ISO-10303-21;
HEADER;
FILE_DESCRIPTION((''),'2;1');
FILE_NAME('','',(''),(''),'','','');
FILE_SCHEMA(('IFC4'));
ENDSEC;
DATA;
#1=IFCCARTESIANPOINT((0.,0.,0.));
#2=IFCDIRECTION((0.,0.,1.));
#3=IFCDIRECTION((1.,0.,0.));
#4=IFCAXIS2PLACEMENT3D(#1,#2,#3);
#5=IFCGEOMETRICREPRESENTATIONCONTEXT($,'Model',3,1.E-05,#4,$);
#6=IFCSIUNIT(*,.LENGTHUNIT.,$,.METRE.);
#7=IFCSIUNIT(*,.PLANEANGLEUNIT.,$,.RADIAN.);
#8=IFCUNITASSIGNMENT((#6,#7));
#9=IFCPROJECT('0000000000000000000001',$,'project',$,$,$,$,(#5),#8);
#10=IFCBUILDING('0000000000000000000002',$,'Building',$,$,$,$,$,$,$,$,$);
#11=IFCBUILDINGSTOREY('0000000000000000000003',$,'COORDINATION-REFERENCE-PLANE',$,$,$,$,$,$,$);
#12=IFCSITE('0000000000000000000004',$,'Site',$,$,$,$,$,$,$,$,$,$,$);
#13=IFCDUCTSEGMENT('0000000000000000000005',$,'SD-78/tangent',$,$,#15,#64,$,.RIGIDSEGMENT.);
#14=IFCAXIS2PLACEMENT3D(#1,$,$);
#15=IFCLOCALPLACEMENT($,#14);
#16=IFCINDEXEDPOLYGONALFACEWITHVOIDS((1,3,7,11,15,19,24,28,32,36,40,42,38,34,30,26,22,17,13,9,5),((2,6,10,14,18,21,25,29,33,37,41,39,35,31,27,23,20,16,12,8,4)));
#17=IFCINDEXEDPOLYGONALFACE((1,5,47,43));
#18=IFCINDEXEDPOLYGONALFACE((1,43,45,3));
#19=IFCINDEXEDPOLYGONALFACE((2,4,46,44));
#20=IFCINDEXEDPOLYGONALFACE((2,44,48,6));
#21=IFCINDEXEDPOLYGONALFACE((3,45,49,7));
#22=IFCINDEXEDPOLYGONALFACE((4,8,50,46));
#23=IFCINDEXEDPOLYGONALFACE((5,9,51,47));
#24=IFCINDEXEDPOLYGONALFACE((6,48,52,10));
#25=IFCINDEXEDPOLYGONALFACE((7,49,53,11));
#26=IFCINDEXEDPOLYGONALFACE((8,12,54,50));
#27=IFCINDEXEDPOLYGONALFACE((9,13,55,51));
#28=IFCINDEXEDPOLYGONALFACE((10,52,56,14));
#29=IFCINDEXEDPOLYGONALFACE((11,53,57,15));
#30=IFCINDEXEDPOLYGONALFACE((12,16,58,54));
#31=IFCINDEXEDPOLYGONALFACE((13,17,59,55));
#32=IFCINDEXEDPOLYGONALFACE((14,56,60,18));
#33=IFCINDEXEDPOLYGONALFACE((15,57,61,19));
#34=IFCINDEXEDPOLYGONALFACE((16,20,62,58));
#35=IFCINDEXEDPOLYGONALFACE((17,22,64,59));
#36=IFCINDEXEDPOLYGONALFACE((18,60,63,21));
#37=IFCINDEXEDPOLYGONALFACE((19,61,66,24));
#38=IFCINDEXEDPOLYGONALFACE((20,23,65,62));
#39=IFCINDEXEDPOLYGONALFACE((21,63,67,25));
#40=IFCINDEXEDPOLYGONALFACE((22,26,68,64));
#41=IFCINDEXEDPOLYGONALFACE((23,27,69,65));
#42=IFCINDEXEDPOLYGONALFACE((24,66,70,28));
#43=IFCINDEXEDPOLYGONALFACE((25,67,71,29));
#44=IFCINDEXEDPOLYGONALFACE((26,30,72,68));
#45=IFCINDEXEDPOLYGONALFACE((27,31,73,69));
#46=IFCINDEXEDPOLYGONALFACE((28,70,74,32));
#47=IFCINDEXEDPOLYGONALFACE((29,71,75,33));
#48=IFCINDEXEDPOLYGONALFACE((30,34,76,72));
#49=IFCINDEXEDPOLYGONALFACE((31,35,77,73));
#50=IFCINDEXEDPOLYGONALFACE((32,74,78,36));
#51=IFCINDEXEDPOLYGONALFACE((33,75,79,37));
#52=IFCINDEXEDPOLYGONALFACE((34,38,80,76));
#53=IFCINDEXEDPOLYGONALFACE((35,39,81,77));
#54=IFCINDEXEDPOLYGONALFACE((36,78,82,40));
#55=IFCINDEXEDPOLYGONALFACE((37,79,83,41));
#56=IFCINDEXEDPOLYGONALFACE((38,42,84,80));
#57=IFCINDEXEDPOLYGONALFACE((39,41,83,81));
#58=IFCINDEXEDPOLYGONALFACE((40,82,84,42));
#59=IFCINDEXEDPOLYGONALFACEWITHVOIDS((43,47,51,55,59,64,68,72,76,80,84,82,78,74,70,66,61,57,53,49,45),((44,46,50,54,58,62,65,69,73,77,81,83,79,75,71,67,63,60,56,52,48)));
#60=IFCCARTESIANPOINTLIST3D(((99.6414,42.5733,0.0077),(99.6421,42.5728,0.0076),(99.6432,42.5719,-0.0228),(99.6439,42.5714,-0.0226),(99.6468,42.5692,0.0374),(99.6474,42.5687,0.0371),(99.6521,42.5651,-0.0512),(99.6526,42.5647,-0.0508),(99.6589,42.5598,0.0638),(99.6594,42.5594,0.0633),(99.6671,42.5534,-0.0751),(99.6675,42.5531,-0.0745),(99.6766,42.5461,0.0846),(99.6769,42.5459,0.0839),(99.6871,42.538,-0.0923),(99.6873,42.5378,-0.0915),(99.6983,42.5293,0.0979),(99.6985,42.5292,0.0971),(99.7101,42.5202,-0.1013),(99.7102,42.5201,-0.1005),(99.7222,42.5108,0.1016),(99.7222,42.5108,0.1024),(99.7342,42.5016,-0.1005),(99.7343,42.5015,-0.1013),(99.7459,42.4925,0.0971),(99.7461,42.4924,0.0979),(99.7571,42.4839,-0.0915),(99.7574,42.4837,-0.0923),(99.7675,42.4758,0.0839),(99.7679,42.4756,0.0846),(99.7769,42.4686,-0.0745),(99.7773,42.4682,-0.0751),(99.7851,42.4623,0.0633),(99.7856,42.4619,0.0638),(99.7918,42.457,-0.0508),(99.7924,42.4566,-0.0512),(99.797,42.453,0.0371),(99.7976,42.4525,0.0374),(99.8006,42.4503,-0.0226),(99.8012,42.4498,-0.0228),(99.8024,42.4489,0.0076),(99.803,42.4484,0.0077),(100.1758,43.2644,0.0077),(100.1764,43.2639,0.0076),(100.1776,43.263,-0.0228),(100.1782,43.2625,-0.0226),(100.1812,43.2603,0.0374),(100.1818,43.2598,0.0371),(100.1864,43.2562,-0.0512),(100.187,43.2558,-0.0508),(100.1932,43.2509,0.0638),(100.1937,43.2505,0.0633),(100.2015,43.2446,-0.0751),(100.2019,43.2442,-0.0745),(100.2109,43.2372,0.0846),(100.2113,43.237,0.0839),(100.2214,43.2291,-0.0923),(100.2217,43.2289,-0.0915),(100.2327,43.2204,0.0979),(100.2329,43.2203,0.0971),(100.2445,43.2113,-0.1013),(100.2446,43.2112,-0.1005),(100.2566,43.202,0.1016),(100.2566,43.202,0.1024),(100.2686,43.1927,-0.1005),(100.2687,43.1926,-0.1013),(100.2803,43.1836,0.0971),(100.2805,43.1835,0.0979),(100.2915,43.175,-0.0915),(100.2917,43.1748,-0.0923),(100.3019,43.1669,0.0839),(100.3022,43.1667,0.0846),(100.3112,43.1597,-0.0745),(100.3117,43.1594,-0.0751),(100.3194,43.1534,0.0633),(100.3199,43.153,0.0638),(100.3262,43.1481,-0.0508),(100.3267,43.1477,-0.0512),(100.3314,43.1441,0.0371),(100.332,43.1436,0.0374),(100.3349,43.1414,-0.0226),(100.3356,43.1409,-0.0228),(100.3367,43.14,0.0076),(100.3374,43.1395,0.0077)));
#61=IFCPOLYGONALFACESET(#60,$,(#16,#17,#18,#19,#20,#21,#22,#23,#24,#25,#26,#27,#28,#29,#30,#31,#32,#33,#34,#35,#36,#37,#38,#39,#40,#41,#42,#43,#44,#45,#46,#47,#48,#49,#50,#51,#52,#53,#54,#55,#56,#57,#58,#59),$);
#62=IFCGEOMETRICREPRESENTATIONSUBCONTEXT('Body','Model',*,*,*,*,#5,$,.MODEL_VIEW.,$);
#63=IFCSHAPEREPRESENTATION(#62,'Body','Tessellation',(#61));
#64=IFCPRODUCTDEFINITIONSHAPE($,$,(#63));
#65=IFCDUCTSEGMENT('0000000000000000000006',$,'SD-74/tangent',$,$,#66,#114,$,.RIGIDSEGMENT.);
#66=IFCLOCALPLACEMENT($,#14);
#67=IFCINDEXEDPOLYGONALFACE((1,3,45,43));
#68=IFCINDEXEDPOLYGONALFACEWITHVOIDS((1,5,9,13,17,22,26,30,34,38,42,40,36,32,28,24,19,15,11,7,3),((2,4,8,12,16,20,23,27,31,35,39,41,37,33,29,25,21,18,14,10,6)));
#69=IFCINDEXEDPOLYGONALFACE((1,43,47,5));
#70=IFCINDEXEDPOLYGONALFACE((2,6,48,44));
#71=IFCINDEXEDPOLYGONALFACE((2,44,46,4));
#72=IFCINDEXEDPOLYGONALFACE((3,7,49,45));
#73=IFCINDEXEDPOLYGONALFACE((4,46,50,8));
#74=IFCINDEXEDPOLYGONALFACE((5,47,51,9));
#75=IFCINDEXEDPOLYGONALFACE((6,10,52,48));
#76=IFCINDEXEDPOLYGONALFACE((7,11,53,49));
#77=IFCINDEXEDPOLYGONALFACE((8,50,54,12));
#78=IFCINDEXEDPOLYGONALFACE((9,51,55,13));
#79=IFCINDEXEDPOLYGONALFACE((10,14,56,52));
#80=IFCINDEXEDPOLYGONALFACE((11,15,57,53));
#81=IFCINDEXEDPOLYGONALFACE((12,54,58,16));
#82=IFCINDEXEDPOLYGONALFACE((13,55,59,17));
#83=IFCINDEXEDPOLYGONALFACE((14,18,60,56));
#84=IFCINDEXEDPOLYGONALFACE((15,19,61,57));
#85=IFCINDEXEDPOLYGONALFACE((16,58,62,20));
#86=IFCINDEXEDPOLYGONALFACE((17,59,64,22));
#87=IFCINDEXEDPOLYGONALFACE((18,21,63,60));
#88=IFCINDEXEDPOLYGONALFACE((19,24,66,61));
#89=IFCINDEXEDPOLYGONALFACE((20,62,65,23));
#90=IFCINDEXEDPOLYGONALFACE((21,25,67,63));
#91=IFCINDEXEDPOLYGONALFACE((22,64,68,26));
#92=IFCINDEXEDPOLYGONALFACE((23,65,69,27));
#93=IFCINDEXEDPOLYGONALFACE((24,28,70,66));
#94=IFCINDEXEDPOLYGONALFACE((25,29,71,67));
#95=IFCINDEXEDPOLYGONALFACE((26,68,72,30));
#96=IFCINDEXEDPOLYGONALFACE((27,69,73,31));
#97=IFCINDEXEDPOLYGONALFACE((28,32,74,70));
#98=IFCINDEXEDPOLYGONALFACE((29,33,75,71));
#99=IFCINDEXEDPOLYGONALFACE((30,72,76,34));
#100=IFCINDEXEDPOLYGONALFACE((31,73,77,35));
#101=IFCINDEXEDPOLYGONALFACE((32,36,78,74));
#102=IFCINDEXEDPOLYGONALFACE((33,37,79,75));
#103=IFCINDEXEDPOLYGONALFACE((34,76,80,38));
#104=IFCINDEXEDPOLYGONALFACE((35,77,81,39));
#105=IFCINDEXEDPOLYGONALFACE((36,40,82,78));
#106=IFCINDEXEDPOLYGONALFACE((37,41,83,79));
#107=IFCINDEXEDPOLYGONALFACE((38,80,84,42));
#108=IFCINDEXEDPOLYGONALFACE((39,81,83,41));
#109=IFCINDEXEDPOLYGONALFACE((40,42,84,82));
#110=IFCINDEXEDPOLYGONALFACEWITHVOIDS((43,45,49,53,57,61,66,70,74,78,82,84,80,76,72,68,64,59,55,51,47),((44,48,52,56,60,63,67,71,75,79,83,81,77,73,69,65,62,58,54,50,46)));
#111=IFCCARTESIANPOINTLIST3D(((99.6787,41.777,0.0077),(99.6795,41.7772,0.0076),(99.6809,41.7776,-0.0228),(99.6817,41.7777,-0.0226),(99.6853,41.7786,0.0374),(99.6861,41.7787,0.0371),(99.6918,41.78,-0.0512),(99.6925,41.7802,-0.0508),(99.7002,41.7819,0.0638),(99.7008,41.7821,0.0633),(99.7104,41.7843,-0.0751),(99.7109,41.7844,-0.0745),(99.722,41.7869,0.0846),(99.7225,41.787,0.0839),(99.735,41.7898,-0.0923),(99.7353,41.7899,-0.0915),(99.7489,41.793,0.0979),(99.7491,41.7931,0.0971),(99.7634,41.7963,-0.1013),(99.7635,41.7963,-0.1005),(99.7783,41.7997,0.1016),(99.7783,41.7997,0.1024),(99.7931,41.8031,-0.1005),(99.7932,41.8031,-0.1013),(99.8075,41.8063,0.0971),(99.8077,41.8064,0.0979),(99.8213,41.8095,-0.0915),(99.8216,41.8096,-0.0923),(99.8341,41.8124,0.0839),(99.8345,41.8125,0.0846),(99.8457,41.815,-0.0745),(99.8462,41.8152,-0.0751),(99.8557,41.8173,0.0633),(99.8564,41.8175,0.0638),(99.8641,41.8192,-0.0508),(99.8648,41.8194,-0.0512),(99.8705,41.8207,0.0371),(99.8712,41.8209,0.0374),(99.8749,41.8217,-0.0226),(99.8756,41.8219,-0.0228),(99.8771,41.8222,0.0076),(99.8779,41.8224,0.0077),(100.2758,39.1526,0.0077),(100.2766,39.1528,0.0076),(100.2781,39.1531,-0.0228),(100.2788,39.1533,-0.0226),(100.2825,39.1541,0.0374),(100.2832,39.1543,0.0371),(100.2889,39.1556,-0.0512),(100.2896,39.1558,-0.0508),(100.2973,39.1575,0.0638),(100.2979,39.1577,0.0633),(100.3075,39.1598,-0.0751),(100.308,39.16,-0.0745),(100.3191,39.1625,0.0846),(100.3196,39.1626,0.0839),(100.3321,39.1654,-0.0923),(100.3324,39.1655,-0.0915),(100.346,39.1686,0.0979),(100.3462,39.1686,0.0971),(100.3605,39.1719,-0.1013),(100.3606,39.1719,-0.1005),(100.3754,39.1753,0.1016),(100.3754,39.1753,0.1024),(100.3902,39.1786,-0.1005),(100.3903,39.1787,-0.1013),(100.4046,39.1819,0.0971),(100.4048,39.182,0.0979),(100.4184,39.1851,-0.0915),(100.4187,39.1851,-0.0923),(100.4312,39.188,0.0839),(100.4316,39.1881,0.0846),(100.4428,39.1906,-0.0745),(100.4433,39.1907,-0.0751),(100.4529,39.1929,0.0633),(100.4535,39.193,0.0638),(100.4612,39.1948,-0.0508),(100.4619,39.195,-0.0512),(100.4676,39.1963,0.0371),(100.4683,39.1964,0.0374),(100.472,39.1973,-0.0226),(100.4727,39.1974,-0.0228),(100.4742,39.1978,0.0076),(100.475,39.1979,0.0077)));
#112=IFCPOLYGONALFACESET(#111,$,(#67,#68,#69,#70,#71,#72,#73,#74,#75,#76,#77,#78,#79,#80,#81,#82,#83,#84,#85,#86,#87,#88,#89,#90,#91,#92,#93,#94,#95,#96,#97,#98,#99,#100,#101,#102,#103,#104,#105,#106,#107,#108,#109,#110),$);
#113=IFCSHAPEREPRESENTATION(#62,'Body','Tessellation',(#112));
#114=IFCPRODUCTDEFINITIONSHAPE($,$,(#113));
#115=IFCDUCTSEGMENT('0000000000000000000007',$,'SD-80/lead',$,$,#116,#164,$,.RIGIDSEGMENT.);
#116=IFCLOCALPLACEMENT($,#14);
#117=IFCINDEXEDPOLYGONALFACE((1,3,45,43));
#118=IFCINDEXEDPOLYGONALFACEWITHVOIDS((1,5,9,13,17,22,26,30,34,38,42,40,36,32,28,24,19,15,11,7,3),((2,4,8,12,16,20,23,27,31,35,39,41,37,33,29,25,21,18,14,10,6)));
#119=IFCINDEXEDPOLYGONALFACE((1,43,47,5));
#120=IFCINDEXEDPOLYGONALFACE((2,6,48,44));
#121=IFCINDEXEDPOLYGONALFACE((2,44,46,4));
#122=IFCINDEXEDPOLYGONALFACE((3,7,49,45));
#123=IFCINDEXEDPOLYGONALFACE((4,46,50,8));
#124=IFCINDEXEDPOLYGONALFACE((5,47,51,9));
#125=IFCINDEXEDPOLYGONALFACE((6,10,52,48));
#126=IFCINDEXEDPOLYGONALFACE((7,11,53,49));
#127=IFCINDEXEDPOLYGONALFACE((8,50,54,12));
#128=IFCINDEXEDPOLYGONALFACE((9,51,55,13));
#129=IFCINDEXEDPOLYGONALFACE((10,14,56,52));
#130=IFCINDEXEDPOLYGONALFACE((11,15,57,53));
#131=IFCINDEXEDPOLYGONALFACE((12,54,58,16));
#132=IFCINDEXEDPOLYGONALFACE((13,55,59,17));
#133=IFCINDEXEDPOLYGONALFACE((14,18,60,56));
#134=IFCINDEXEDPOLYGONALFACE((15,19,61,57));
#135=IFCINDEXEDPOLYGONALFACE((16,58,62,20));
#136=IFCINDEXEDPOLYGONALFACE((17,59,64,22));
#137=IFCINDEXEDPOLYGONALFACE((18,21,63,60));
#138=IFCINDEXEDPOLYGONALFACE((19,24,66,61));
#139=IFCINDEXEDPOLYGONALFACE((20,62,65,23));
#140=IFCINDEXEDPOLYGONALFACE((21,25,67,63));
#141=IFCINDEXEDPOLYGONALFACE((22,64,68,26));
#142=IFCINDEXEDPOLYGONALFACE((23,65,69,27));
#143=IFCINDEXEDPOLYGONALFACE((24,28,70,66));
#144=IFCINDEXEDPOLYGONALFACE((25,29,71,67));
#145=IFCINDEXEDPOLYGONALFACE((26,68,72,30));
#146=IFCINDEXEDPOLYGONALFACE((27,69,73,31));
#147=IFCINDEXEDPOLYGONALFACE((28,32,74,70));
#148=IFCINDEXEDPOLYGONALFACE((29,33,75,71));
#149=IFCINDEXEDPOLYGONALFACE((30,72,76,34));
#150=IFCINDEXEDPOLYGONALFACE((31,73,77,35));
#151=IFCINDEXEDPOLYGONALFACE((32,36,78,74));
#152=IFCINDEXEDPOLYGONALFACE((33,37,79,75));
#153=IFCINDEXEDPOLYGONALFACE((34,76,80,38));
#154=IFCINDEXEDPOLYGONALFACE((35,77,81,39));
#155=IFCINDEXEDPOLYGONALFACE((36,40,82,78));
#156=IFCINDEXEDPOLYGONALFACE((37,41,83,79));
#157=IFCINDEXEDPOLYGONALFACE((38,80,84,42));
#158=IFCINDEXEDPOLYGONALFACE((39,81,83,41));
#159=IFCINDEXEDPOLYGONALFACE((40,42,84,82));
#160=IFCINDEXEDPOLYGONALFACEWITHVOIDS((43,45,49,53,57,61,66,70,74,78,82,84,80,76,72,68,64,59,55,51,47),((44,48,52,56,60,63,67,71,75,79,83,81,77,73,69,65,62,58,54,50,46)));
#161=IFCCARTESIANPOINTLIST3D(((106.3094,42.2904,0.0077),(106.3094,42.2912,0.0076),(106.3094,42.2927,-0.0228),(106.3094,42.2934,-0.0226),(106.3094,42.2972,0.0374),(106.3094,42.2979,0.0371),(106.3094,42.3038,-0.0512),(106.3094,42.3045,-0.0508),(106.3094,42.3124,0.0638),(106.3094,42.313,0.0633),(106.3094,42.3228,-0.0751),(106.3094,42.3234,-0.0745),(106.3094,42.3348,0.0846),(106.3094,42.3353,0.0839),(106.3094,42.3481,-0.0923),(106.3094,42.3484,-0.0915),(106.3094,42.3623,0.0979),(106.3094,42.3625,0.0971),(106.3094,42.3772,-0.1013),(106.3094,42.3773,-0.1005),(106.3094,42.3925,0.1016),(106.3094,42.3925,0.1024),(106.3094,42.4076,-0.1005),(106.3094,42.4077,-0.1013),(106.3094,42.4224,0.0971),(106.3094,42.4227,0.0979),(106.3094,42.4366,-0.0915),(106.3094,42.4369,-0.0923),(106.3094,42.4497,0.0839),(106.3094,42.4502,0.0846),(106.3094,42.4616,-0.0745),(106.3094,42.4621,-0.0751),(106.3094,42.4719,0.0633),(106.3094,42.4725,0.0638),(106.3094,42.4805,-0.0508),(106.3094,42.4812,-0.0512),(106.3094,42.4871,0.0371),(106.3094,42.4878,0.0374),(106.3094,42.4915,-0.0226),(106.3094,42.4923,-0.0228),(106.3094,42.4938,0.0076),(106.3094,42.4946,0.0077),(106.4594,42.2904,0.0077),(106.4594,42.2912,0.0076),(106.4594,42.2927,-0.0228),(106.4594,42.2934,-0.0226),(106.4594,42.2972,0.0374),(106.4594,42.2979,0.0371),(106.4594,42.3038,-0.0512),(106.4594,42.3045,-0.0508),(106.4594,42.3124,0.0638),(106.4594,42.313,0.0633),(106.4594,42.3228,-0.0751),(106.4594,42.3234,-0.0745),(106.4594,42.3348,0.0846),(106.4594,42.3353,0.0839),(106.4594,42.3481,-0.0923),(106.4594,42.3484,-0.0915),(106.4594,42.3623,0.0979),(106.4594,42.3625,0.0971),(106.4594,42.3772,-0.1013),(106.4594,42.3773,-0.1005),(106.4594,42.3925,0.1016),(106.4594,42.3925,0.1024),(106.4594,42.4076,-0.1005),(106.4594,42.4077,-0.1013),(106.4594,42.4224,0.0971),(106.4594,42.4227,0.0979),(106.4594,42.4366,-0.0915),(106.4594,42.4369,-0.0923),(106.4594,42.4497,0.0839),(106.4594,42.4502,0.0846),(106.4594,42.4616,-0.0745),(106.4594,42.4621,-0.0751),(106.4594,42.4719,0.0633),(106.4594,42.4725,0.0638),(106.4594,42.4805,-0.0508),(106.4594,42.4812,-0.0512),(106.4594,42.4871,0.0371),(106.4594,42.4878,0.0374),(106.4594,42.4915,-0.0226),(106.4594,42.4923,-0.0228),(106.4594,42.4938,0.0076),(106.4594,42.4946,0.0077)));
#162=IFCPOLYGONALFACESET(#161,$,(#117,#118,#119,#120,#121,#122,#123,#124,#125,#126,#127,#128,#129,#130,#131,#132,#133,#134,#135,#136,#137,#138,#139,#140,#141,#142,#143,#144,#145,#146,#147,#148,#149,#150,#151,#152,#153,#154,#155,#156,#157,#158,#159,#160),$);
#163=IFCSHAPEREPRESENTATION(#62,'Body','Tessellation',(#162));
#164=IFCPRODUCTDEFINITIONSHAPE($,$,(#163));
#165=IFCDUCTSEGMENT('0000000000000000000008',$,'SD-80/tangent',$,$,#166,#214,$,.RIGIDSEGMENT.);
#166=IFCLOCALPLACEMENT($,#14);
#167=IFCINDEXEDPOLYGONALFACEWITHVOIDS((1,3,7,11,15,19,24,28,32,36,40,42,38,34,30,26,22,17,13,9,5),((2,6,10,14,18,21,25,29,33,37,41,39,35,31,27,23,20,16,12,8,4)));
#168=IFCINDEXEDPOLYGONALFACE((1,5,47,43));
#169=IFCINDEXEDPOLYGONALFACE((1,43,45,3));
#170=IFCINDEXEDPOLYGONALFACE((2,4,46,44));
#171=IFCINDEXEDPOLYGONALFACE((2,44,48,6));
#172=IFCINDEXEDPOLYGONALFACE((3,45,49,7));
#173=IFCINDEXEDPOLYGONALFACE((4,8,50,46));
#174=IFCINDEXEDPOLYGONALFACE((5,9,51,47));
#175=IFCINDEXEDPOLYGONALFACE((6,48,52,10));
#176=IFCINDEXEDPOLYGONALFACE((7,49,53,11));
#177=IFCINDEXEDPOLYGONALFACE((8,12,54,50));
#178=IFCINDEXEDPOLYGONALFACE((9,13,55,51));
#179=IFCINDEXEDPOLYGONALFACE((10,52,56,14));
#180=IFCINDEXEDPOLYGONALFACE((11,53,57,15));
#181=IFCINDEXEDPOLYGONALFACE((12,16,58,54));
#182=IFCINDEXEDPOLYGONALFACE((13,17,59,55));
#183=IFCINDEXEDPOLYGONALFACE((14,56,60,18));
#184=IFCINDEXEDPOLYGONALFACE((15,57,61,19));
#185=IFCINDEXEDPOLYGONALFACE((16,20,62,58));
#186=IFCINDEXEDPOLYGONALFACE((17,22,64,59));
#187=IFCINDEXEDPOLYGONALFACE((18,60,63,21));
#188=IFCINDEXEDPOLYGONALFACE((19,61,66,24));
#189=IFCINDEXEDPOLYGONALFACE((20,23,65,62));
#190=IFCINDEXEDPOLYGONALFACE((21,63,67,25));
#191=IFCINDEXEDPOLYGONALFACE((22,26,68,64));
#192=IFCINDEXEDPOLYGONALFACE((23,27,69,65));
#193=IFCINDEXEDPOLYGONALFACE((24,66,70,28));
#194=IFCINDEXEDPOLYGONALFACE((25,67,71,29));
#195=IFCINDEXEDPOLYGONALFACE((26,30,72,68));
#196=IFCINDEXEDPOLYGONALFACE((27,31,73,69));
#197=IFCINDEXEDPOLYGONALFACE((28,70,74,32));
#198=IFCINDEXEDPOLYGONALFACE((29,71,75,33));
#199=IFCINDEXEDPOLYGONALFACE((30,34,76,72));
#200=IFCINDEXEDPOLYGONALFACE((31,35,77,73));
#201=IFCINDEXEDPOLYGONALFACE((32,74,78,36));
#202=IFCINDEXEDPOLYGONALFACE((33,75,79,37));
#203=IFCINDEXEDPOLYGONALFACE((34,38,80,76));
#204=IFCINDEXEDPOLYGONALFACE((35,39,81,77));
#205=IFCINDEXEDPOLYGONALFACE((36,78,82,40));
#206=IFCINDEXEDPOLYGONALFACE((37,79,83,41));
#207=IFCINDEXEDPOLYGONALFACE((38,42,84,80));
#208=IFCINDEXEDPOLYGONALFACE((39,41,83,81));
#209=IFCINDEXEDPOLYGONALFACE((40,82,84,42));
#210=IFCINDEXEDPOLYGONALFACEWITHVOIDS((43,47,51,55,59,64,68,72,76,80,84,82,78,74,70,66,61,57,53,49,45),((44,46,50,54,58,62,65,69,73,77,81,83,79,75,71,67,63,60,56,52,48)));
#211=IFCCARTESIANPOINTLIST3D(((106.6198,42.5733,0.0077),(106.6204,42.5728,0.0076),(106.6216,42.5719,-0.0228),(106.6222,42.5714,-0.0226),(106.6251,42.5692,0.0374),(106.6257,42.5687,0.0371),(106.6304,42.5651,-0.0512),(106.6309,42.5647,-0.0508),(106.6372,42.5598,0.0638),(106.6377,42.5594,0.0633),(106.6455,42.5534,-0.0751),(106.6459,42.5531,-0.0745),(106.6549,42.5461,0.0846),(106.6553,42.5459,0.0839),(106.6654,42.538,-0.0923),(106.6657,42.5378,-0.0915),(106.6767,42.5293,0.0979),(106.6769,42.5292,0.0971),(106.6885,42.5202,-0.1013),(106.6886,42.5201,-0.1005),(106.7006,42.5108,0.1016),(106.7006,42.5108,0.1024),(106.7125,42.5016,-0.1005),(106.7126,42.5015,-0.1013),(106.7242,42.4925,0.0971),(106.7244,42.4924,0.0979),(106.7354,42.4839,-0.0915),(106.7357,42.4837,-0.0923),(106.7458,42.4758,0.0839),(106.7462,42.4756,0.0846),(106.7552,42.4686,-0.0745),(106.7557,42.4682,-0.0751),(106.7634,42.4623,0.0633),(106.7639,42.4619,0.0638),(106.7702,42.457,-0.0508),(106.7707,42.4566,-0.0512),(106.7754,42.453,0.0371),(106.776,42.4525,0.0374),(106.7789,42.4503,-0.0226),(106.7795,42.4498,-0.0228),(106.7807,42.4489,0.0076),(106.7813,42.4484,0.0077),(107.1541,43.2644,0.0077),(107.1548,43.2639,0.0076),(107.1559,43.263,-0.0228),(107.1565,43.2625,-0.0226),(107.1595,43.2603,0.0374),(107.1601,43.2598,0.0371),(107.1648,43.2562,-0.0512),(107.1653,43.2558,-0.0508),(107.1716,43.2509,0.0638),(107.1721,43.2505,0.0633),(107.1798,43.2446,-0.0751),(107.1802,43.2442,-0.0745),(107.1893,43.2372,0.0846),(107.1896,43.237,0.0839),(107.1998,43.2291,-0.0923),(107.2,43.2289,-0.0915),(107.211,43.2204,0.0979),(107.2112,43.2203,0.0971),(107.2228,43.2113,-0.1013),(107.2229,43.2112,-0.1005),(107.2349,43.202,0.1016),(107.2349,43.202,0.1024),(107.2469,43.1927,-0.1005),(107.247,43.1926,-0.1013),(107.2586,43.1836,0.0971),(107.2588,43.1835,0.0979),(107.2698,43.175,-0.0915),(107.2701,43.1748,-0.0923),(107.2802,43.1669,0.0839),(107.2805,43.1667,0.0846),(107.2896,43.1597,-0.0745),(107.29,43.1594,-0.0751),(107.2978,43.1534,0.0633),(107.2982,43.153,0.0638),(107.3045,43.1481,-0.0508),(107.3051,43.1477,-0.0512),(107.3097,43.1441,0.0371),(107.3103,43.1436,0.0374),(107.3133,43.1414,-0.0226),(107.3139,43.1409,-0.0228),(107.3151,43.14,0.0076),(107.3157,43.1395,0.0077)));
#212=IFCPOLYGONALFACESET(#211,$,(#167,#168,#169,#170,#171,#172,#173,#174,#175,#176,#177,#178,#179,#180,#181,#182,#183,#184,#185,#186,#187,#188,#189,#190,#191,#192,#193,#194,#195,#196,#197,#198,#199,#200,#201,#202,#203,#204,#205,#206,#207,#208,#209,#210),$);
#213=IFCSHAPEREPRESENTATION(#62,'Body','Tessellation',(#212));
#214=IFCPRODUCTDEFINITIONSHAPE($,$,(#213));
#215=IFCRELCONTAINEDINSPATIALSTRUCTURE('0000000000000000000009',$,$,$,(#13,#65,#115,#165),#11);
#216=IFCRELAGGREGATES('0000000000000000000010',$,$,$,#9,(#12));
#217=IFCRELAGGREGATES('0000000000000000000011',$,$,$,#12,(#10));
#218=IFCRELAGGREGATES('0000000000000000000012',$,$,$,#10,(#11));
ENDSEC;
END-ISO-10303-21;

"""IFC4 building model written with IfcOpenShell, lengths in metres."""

from ifc_helpers import new_model, si_unit, frame, origin_with_axes, place, context, subcontext, project, spatial, hollow_circle, extrude, element, save


model = new_model("IFC4")

# Units and contexts
model_context_1 = context("Model", 3, precision=1e-05, world=origin_with_axes())
body_context_1 = subcontext(model_context_1, "Body", "Model", "MODEL_VIEW")
ifc_project = project(units=[si_unit("LENGTHUNIT", "METRE"), si_unit("PLANEANGLEUNIT", "RADIAN")], contexts=[model_context_1])

# Site, building, storey
site = spatial("IfcSite", under=ifc_project, Name="Site")
building = spatial("IfcBuilding", under=site, Name="Building")
storey = spatial("IfcBuildingStorey", under=building, Name="COORDINATION-REFERENCE-PLANE")

# Duct segment
duct_segment_1_placement = place(None, frame((99.7222, 42.5108, 0.0), z_axis=(0.611676, 0.791108, 0.0), x_axis=(0.0, 0.0, 1.0)))
element("IfcDuctSegment", 1, at=duct_segment_1_placement, inside=storey, Name="SD-78/tangent", PredefinedType="RIGIDSEGMENT", context=body_context_1, shape_type="SweptSolid", body=[
    extrude(hollow_circle(Radius=0.1024, WallThickness=0.0008), origin_with_axes(), (0.0, 0.0, 1.0), 0.8736),
])

# Duct segment
duct_segment_2_placement = place(None, frame((99.7783, 41.7997, 0.0), z_axis=(0.221849, -0.975081, 0.0), x_axis=(0.0, 0.0, 1.0)))
element("IfcDuctSegment", 2, at=duct_segment_2_placement, inside=storey, Name="SD-74/tangent", PredefinedType="RIGIDSEGMENT", context=body_context_1, shape_type="SweptSolid", body=[
    extrude(hollow_circle(Radius=0.1024, WallThickness=0.0008), origin_with_axes(), (0.0, 0.0, 1.0), 2.6915),
])

# Duct segment
duct_segment_3_placement = place(None, frame((106.3094, 42.3925, 0.0), z_axis=(1.0, 0.0, 0.0), x_axis=(0.0, 0.0, 1.0)))
element("IfcDuctSegment", 3, at=duct_segment_3_placement, inside=storey, Name="SD-80/lead", PredefinedType="RIGIDSEGMENT", context=body_context_1, shape_type="SweptSolid", body=[
    extrude(hollow_circle(Radius=0.1024, WallThickness=0.0008), origin_with_axes(), (0.0, 0.0, 1.0), 0.15),
])

# Duct segment
duct_segment_4_placement = place(None, frame((106.7006, 42.5108, 0.0), z_axis=(0.611676, 0.791108, 0.0), x_axis=(0.0, 0.0, 1.0)))
element("IfcDuctSegment", 4, at=duct_segment_4_placement, inside=storey, Name="SD-80/tangent", PredefinedType="RIGIDSEGMENT", context=body_context_1, shape_type="SweptSolid", body=[
    extrude(hollow_circle(Radius=0.1024, WallThickness=0.0008), origin_with_axes(), (0.0, 0.0, 1.0), 0.8736),
])

save(model, "model.ifc")
